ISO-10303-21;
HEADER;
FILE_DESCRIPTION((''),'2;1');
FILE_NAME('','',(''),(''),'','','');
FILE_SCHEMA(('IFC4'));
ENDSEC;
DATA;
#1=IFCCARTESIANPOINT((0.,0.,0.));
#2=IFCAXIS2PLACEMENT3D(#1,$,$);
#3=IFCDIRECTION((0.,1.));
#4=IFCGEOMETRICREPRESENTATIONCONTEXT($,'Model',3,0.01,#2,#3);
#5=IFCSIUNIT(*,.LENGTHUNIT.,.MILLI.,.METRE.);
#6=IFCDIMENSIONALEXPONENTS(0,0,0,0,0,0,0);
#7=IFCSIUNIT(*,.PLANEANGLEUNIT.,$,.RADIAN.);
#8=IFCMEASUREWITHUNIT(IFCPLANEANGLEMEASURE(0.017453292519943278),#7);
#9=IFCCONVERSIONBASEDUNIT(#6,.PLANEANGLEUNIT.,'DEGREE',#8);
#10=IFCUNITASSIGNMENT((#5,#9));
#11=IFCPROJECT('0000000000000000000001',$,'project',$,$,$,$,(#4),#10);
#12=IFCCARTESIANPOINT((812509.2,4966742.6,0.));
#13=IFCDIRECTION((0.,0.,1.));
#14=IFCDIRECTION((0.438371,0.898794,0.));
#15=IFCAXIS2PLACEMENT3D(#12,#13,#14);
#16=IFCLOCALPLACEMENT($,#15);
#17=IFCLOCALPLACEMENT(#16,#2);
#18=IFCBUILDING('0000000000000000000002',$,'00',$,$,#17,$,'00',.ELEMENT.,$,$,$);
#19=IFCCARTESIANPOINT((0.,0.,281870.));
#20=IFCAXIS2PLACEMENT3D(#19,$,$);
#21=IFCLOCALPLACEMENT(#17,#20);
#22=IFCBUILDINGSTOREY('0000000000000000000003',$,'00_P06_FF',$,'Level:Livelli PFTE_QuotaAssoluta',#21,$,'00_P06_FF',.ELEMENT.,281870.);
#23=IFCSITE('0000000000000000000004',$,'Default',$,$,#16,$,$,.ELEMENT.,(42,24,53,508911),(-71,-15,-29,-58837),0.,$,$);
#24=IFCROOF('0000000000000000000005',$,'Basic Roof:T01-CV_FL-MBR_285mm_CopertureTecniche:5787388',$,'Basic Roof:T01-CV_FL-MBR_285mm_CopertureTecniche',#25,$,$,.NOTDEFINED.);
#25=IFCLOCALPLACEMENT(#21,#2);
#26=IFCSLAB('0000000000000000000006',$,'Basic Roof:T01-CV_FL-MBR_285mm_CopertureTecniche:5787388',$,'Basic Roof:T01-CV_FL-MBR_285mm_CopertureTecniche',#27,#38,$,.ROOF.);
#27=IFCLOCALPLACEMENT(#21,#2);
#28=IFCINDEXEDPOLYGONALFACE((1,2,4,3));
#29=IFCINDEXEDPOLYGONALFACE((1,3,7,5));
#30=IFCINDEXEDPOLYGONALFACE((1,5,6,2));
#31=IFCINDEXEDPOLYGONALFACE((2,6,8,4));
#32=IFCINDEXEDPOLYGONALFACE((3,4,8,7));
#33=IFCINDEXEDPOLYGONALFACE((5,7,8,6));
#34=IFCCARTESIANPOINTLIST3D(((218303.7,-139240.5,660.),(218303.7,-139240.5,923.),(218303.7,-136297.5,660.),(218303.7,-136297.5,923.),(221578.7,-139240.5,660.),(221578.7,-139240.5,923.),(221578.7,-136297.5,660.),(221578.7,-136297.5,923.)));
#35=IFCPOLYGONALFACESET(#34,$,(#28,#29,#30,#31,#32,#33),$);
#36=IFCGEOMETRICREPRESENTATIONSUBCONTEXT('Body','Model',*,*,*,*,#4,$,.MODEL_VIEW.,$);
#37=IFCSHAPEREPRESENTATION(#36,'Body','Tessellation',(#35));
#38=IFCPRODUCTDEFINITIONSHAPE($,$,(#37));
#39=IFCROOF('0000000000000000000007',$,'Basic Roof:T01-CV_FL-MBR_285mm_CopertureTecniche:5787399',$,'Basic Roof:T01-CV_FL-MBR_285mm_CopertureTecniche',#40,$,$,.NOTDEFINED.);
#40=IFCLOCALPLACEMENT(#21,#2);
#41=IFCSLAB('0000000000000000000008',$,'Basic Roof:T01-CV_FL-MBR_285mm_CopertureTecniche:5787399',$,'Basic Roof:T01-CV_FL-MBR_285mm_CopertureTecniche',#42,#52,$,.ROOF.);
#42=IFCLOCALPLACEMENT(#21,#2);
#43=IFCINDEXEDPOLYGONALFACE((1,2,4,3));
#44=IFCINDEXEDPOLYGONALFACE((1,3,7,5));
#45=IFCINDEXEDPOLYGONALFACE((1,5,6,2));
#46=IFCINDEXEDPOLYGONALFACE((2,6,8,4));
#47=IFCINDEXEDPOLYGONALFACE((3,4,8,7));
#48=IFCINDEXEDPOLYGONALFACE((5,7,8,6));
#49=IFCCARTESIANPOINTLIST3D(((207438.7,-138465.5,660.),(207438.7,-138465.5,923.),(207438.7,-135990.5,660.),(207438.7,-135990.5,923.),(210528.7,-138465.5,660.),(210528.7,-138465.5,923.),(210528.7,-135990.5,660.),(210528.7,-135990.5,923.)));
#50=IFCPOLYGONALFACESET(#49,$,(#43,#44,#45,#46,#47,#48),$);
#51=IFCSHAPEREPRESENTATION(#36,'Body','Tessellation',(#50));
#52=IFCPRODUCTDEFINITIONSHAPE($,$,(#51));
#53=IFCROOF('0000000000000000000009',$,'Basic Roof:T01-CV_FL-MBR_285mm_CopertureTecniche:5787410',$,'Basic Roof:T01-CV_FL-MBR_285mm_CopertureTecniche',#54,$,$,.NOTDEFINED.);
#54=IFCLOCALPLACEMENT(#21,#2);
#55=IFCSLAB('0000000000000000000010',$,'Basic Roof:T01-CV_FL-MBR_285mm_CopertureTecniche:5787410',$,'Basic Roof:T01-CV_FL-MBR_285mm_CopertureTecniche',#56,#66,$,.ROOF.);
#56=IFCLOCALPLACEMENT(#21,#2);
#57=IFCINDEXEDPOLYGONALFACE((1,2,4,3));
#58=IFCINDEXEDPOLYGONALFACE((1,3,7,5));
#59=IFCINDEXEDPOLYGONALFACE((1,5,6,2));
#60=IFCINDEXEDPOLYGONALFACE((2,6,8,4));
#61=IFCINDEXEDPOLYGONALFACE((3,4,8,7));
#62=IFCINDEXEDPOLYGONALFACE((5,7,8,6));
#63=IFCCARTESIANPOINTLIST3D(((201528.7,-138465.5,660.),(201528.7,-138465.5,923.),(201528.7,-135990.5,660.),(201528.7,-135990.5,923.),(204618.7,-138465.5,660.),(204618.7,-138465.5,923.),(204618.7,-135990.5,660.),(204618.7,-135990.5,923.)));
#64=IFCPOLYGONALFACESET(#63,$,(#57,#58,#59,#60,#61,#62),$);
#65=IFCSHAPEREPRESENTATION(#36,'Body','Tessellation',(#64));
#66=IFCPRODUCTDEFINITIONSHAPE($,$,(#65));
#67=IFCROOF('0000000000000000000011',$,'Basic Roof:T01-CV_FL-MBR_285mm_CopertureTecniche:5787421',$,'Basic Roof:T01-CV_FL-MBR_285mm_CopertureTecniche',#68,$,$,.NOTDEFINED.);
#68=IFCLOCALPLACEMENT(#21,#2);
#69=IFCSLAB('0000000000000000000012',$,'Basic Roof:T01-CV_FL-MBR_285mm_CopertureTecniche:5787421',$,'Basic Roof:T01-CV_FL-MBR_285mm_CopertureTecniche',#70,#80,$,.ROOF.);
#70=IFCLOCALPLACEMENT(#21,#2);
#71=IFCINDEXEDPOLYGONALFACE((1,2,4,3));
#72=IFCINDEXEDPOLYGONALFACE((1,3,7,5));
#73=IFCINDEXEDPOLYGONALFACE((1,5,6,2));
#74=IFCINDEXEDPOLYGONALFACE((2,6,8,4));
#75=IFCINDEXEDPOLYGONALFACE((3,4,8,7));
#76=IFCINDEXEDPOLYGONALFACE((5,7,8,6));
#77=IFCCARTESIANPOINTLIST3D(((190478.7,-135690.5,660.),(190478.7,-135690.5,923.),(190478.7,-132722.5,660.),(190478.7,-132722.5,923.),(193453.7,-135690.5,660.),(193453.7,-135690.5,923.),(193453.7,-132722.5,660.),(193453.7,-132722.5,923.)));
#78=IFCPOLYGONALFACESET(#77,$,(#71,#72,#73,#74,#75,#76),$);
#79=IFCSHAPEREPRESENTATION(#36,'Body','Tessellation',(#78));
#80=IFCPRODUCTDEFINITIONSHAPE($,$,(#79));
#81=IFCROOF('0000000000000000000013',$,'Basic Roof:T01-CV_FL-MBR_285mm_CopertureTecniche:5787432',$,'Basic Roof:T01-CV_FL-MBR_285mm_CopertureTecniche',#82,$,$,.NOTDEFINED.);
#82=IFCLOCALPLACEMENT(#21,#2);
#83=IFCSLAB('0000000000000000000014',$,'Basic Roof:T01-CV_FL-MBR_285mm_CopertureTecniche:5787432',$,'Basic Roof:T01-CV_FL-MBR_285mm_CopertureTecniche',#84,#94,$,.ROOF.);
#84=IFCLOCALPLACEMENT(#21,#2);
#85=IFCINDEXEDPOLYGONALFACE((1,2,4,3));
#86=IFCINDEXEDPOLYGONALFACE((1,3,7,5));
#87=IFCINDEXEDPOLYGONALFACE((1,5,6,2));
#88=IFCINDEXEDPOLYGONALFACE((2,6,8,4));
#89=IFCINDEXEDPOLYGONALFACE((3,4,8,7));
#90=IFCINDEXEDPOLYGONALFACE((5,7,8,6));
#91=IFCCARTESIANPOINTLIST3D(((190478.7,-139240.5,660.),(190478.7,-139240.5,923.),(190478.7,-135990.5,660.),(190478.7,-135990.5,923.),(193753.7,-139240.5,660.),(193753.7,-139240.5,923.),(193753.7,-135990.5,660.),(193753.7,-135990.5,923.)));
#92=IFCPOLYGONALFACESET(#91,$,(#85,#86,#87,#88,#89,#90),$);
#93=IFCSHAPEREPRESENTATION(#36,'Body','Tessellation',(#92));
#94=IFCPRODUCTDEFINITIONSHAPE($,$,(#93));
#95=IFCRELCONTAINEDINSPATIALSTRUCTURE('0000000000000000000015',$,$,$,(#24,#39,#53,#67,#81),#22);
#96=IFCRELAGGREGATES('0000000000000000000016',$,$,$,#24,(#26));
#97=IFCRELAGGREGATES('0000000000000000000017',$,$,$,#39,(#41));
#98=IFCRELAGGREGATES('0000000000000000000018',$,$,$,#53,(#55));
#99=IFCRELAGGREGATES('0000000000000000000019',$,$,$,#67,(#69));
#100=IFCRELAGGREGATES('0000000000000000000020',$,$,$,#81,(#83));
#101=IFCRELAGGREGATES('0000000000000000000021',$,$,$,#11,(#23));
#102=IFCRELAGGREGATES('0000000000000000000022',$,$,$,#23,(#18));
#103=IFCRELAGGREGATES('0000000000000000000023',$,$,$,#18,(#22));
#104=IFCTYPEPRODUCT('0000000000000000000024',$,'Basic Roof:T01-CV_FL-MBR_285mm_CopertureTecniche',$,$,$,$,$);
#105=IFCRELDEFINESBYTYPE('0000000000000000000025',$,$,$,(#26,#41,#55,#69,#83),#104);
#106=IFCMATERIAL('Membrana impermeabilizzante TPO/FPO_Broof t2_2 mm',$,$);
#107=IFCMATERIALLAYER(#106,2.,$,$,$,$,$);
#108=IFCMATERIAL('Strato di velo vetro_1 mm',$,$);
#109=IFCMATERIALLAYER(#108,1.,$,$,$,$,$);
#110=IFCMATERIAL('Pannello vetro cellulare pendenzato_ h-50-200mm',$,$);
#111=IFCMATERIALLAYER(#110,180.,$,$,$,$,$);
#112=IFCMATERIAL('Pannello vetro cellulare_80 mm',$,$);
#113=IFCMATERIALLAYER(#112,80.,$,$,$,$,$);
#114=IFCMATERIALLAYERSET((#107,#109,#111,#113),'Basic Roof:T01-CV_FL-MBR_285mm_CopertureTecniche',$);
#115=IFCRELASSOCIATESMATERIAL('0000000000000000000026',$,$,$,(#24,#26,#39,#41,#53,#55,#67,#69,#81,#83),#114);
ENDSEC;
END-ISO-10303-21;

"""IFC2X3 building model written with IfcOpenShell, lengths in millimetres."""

from ifc_helpers import new_model, entity, si_unit, converted_unit, direction, frame, frame_2d, origin, place, context, subcontext, project, spatial, rectangle, extrude, material, layer, layer_set, type_object, element, aggregate, save


model = new_model("IFC2X3")

# Units and contexts
model_context = context("Model", 3, precision=0.01, world=origin(), true_north=direction((0.0, 1.0)))
body_context = subcontext(model_context, "Body", "Model", "MODEL_VIEW")
ifc_project = project(units=[si_unit("LENGTHUNIT", "METRE", prefix="MILLI"), converted_unit("PLANEANGLEUNIT", "DEGREE", entity("IfcPlaneAngleMeasure", 0.017453292519943278), si_unit("PLANEANGLEUNIT", "RADIAN"), dimensions=[0, 0, 0, 0, 0, 0, 0])], contexts=[model_context])

# Site, building, storey
site_placement = place(None, frame((812509.2, 4966742.6, 0.0), z_axis=(0.0, 0.0, 1.0), x_axis=(0.438371, 0.898794, 0.0)))
site = spatial("IfcSite", under=ifc_project, at=site_placement, Name="Default", CompositionType="ELEMENT", RefLatitude=(42, 24, 53, 508911), RefLongitude=(-71, -15, -29, -58837), RefElevation=0.0)
building_placement = place(site_placement, origin())
building = spatial("IfcBuilding", under=site, at=building_placement, Name="00", LongName="00", CompositionType="ELEMENT")
storey_placement = place(building_placement, frame((0.0, 0.0, 281870.0)))
storey = spatial("IfcBuildingStorey", under=building, at=storey_placement, Name="00_P06_FF", ObjectType="Level:Livelli PFTE_QuotaAssoluta", LongName="00_P06_FF", CompositionType="ELEMENT", Elevation=281870.0)

# Roofs, slabs
ifc_material_1 = material(Name="Membrana impermeabilizzante TPO/FPO_Broof t2_2 mm")
ifc_layer_1 = layer(ifc_material_1, 2.0)
ifc_material_2 = material(Name="Strato di velo vetro_1 mm")
ifc_layer_2 = layer(ifc_material_2, 1.0)
ifc_material_3 = material(Name="Pannello vetro cellulare pendenzato_ h-50-200mm")
ifc_layer_3 = layer(ifc_material_3, 180.0)
ifc_material_4 = material(Name="Pannello vetro cellulare_80 mm")
ifc_layer_4 = layer(ifc_material_4, 80.0)
ifc_layer_set = layer_set([ifc_layer_1, ifc_layer_2, ifc_layer_3, ifc_layer_4], Name="Basic Roof:T01-CV_FL-MBR_285mm_CopertureTecniche")
type_product = type_object("IfcTypeProduct", Name="Basic Roof:T01-CV_FL-MBR_285mm_CopertureTecniche")
roof_1_placement = place(storey_placement, frame((218303.7, -139240.5, 660.0)))
roof_1 = element("IfcRoof", 1, at=roof_1_placement, inside=storey, material=ifc_layer_set, Name="Basic Roof:T01-CV_FL-MBR_285mm_CopertureTecniche:5787388", ObjectType="Basic Roof:T01-CV_FL-MBR_285mm_CopertureTecniche", ShapeType="NOTDEFINED")
slab_1_placement = place(roof_1_placement, origin())
slab_1 = element("IfcSlab", 2, at=slab_1_placement, type_object=type_product, material=ifc_layer_set, Name="Basic Roof:T01-CV_FL-MBR_285mm_CopertureTecniche:5787388", ObjectType="Basic Roof:T01-CV_FL-MBR_285mm_CopertureTecniche", PredefinedType="ROOF", context=body_context, shape_type="SweptSolid", body=[
    extrude(rectangle(XDim=2943.0, YDim=3275.0, at=frame_2d((0.0, 0.0), x_axis=(0.0, 1.0))), frame((1637.5, 1471.5, 0.0)), (0.0, 0.0, 1.0), 263.0),
])
aggregate(roof_1, [slab_1])
roof_2_placement = place(storey_placement, frame((207438.7, -138465.5, 660.0)))
roof_2 = element("IfcRoof", 3, at=roof_2_placement, inside=storey, material=ifc_layer_set, Name="Basic Roof:T01-CV_FL-MBR_285mm_CopertureTecniche:5787399", ObjectType="Basic Roof:T01-CV_FL-MBR_285mm_CopertureTecniche", ShapeType="NOTDEFINED")
slab_2_placement = place(roof_2_placement, origin())
slab_2 = element("IfcSlab", 4, at=slab_2_placement, type_object=type_product, material=ifc_layer_set, Name="Basic Roof:T01-CV_FL-MBR_285mm_CopertureTecniche:5787399", ObjectType="Basic Roof:T01-CV_FL-MBR_285mm_CopertureTecniche", PredefinedType="ROOF", context=body_context, shape_type="SweptSolid", body=[
    extrude(rectangle(XDim=2475.0, YDim=3090.0, at=frame_2d((0.0, 0.0), x_axis=(0.0, 1.0))), frame((1545.0, 1237.5, 0.0)), (0.0, 0.0, 1.0), 263.0),
])
aggregate(roof_2, [slab_2])
roof_3_placement = place(storey_placement, frame((201528.7, -138465.5, 660.0)))
roof_3 = element("IfcRoof", 5, at=roof_3_placement, inside=storey, material=ifc_layer_set, Name="Basic Roof:T01-CV_FL-MBR_285mm_CopertureTecniche:5787410", ObjectType="Basic Roof:T01-CV_FL-MBR_285mm_CopertureTecniche", ShapeType="NOTDEFINED")
slab_3_placement = place(roof_3_placement, origin())
slab_3 = element("IfcSlab", 6, at=slab_3_placement, type_object=type_product, material=ifc_layer_set, Name="Basic Roof:T01-CV_FL-MBR_285mm_CopertureTecniche:5787410", ObjectType="Basic Roof:T01-CV_FL-MBR_285mm_CopertureTecniche", PredefinedType="ROOF", context=body_context, shape_type="SweptSolid", body=[
    extrude(rectangle(XDim=3090.0, YDim=2475.0, at=frame_2d((0.0, 0.0), x_axis=(-1.0, 0.0))), frame((1545.0, 1237.5, 0.0)), (0.0, 0.0, 1.0), 263.0),
])
aggregate(roof_3, [slab_3])
roof_4_placement = place(storey_placement, frame((190478.7, -135690.5, 660.0)))
roof_4 = element("IfcRoof", 7, at=roof_4_placement, inside=storey, material=ifc_layer_set, Name="Basic Roof:T01-CV_FL-MBR_285mm_CopertureTecniche:5787421", ObjectType="Basic Roof:T01-CV_FL-MBR_285mm_CopertureTecniche", ShapeType="NOTDEFINED")
slab_4_placement = place(roof_4_placement, origin())
slab_4 = element("IfcSlab", 8, at=slab_4_placement, type_object=type_product, material=ifc_layer_set, Name="Basic Roof:T01-CV_FL-MBR_285mm_CopertureTecniche:5787421", ObjectType="Basic Roof:T01-CV_FL-MBR_285mm_CopertureTecniche", PredefinedType="ROOF", context=body_context, shape_type="SweptSolid", body=[
    extrude(rectangle(XDim=2975.0, YDim=2968.0, at=frame_2d((0.0, 0.0), x_axis=(-1.0, 0.0))), frame((1487.5, 1484.0, 0.0)), (0.0, 0.0, 1.0), 263.0),
])
aggregate(roof_4, [slab_4])
roof_5_placement = place(storey_placement, frame((190478.7, -139240.5, 660.0)))
roof_5 = element("IfcRoof", 9, at=roof_5_placement, inside=storey, material=ifc_layer_set, Name="Basic Roof:T01-CV_FL-MBR_285mm_CopertureTecniche:5787432", ObjectType="Basic Roof:T01-CV_FL-MBR_285mm_CopertureTecniche", ShapeType="NOTDEFINED")
slab_5_placement = place(roof_5_placement, origin())
slab_5 = element("IfcSlab", 10, at=slab_5_placement, type_object=type_product, material=ifc_layer_set, Name="Basic Roof:T01-CV_FL-MBR_285mm_CopertureTecniche:5787432", ObjectType="Basic Roof:T01-CV_FL-MBR_285mm_CopertureTecniche", PredefinedType="ROOF", context=body_context, shape_type="SweptSolid", body=[
    extrude(rectangle(XDim=3275.0, YDim=3250.0, at=frame_2d((0.0, 0.0), x_axis=(1.0, 0.0))), frame((1637.5, 1625.0, 0.0)), (0.0, 0.0, 1.0), 263.0),
])
aggregate(roof_5, [slab_5])

save(model, "model.ifc")
